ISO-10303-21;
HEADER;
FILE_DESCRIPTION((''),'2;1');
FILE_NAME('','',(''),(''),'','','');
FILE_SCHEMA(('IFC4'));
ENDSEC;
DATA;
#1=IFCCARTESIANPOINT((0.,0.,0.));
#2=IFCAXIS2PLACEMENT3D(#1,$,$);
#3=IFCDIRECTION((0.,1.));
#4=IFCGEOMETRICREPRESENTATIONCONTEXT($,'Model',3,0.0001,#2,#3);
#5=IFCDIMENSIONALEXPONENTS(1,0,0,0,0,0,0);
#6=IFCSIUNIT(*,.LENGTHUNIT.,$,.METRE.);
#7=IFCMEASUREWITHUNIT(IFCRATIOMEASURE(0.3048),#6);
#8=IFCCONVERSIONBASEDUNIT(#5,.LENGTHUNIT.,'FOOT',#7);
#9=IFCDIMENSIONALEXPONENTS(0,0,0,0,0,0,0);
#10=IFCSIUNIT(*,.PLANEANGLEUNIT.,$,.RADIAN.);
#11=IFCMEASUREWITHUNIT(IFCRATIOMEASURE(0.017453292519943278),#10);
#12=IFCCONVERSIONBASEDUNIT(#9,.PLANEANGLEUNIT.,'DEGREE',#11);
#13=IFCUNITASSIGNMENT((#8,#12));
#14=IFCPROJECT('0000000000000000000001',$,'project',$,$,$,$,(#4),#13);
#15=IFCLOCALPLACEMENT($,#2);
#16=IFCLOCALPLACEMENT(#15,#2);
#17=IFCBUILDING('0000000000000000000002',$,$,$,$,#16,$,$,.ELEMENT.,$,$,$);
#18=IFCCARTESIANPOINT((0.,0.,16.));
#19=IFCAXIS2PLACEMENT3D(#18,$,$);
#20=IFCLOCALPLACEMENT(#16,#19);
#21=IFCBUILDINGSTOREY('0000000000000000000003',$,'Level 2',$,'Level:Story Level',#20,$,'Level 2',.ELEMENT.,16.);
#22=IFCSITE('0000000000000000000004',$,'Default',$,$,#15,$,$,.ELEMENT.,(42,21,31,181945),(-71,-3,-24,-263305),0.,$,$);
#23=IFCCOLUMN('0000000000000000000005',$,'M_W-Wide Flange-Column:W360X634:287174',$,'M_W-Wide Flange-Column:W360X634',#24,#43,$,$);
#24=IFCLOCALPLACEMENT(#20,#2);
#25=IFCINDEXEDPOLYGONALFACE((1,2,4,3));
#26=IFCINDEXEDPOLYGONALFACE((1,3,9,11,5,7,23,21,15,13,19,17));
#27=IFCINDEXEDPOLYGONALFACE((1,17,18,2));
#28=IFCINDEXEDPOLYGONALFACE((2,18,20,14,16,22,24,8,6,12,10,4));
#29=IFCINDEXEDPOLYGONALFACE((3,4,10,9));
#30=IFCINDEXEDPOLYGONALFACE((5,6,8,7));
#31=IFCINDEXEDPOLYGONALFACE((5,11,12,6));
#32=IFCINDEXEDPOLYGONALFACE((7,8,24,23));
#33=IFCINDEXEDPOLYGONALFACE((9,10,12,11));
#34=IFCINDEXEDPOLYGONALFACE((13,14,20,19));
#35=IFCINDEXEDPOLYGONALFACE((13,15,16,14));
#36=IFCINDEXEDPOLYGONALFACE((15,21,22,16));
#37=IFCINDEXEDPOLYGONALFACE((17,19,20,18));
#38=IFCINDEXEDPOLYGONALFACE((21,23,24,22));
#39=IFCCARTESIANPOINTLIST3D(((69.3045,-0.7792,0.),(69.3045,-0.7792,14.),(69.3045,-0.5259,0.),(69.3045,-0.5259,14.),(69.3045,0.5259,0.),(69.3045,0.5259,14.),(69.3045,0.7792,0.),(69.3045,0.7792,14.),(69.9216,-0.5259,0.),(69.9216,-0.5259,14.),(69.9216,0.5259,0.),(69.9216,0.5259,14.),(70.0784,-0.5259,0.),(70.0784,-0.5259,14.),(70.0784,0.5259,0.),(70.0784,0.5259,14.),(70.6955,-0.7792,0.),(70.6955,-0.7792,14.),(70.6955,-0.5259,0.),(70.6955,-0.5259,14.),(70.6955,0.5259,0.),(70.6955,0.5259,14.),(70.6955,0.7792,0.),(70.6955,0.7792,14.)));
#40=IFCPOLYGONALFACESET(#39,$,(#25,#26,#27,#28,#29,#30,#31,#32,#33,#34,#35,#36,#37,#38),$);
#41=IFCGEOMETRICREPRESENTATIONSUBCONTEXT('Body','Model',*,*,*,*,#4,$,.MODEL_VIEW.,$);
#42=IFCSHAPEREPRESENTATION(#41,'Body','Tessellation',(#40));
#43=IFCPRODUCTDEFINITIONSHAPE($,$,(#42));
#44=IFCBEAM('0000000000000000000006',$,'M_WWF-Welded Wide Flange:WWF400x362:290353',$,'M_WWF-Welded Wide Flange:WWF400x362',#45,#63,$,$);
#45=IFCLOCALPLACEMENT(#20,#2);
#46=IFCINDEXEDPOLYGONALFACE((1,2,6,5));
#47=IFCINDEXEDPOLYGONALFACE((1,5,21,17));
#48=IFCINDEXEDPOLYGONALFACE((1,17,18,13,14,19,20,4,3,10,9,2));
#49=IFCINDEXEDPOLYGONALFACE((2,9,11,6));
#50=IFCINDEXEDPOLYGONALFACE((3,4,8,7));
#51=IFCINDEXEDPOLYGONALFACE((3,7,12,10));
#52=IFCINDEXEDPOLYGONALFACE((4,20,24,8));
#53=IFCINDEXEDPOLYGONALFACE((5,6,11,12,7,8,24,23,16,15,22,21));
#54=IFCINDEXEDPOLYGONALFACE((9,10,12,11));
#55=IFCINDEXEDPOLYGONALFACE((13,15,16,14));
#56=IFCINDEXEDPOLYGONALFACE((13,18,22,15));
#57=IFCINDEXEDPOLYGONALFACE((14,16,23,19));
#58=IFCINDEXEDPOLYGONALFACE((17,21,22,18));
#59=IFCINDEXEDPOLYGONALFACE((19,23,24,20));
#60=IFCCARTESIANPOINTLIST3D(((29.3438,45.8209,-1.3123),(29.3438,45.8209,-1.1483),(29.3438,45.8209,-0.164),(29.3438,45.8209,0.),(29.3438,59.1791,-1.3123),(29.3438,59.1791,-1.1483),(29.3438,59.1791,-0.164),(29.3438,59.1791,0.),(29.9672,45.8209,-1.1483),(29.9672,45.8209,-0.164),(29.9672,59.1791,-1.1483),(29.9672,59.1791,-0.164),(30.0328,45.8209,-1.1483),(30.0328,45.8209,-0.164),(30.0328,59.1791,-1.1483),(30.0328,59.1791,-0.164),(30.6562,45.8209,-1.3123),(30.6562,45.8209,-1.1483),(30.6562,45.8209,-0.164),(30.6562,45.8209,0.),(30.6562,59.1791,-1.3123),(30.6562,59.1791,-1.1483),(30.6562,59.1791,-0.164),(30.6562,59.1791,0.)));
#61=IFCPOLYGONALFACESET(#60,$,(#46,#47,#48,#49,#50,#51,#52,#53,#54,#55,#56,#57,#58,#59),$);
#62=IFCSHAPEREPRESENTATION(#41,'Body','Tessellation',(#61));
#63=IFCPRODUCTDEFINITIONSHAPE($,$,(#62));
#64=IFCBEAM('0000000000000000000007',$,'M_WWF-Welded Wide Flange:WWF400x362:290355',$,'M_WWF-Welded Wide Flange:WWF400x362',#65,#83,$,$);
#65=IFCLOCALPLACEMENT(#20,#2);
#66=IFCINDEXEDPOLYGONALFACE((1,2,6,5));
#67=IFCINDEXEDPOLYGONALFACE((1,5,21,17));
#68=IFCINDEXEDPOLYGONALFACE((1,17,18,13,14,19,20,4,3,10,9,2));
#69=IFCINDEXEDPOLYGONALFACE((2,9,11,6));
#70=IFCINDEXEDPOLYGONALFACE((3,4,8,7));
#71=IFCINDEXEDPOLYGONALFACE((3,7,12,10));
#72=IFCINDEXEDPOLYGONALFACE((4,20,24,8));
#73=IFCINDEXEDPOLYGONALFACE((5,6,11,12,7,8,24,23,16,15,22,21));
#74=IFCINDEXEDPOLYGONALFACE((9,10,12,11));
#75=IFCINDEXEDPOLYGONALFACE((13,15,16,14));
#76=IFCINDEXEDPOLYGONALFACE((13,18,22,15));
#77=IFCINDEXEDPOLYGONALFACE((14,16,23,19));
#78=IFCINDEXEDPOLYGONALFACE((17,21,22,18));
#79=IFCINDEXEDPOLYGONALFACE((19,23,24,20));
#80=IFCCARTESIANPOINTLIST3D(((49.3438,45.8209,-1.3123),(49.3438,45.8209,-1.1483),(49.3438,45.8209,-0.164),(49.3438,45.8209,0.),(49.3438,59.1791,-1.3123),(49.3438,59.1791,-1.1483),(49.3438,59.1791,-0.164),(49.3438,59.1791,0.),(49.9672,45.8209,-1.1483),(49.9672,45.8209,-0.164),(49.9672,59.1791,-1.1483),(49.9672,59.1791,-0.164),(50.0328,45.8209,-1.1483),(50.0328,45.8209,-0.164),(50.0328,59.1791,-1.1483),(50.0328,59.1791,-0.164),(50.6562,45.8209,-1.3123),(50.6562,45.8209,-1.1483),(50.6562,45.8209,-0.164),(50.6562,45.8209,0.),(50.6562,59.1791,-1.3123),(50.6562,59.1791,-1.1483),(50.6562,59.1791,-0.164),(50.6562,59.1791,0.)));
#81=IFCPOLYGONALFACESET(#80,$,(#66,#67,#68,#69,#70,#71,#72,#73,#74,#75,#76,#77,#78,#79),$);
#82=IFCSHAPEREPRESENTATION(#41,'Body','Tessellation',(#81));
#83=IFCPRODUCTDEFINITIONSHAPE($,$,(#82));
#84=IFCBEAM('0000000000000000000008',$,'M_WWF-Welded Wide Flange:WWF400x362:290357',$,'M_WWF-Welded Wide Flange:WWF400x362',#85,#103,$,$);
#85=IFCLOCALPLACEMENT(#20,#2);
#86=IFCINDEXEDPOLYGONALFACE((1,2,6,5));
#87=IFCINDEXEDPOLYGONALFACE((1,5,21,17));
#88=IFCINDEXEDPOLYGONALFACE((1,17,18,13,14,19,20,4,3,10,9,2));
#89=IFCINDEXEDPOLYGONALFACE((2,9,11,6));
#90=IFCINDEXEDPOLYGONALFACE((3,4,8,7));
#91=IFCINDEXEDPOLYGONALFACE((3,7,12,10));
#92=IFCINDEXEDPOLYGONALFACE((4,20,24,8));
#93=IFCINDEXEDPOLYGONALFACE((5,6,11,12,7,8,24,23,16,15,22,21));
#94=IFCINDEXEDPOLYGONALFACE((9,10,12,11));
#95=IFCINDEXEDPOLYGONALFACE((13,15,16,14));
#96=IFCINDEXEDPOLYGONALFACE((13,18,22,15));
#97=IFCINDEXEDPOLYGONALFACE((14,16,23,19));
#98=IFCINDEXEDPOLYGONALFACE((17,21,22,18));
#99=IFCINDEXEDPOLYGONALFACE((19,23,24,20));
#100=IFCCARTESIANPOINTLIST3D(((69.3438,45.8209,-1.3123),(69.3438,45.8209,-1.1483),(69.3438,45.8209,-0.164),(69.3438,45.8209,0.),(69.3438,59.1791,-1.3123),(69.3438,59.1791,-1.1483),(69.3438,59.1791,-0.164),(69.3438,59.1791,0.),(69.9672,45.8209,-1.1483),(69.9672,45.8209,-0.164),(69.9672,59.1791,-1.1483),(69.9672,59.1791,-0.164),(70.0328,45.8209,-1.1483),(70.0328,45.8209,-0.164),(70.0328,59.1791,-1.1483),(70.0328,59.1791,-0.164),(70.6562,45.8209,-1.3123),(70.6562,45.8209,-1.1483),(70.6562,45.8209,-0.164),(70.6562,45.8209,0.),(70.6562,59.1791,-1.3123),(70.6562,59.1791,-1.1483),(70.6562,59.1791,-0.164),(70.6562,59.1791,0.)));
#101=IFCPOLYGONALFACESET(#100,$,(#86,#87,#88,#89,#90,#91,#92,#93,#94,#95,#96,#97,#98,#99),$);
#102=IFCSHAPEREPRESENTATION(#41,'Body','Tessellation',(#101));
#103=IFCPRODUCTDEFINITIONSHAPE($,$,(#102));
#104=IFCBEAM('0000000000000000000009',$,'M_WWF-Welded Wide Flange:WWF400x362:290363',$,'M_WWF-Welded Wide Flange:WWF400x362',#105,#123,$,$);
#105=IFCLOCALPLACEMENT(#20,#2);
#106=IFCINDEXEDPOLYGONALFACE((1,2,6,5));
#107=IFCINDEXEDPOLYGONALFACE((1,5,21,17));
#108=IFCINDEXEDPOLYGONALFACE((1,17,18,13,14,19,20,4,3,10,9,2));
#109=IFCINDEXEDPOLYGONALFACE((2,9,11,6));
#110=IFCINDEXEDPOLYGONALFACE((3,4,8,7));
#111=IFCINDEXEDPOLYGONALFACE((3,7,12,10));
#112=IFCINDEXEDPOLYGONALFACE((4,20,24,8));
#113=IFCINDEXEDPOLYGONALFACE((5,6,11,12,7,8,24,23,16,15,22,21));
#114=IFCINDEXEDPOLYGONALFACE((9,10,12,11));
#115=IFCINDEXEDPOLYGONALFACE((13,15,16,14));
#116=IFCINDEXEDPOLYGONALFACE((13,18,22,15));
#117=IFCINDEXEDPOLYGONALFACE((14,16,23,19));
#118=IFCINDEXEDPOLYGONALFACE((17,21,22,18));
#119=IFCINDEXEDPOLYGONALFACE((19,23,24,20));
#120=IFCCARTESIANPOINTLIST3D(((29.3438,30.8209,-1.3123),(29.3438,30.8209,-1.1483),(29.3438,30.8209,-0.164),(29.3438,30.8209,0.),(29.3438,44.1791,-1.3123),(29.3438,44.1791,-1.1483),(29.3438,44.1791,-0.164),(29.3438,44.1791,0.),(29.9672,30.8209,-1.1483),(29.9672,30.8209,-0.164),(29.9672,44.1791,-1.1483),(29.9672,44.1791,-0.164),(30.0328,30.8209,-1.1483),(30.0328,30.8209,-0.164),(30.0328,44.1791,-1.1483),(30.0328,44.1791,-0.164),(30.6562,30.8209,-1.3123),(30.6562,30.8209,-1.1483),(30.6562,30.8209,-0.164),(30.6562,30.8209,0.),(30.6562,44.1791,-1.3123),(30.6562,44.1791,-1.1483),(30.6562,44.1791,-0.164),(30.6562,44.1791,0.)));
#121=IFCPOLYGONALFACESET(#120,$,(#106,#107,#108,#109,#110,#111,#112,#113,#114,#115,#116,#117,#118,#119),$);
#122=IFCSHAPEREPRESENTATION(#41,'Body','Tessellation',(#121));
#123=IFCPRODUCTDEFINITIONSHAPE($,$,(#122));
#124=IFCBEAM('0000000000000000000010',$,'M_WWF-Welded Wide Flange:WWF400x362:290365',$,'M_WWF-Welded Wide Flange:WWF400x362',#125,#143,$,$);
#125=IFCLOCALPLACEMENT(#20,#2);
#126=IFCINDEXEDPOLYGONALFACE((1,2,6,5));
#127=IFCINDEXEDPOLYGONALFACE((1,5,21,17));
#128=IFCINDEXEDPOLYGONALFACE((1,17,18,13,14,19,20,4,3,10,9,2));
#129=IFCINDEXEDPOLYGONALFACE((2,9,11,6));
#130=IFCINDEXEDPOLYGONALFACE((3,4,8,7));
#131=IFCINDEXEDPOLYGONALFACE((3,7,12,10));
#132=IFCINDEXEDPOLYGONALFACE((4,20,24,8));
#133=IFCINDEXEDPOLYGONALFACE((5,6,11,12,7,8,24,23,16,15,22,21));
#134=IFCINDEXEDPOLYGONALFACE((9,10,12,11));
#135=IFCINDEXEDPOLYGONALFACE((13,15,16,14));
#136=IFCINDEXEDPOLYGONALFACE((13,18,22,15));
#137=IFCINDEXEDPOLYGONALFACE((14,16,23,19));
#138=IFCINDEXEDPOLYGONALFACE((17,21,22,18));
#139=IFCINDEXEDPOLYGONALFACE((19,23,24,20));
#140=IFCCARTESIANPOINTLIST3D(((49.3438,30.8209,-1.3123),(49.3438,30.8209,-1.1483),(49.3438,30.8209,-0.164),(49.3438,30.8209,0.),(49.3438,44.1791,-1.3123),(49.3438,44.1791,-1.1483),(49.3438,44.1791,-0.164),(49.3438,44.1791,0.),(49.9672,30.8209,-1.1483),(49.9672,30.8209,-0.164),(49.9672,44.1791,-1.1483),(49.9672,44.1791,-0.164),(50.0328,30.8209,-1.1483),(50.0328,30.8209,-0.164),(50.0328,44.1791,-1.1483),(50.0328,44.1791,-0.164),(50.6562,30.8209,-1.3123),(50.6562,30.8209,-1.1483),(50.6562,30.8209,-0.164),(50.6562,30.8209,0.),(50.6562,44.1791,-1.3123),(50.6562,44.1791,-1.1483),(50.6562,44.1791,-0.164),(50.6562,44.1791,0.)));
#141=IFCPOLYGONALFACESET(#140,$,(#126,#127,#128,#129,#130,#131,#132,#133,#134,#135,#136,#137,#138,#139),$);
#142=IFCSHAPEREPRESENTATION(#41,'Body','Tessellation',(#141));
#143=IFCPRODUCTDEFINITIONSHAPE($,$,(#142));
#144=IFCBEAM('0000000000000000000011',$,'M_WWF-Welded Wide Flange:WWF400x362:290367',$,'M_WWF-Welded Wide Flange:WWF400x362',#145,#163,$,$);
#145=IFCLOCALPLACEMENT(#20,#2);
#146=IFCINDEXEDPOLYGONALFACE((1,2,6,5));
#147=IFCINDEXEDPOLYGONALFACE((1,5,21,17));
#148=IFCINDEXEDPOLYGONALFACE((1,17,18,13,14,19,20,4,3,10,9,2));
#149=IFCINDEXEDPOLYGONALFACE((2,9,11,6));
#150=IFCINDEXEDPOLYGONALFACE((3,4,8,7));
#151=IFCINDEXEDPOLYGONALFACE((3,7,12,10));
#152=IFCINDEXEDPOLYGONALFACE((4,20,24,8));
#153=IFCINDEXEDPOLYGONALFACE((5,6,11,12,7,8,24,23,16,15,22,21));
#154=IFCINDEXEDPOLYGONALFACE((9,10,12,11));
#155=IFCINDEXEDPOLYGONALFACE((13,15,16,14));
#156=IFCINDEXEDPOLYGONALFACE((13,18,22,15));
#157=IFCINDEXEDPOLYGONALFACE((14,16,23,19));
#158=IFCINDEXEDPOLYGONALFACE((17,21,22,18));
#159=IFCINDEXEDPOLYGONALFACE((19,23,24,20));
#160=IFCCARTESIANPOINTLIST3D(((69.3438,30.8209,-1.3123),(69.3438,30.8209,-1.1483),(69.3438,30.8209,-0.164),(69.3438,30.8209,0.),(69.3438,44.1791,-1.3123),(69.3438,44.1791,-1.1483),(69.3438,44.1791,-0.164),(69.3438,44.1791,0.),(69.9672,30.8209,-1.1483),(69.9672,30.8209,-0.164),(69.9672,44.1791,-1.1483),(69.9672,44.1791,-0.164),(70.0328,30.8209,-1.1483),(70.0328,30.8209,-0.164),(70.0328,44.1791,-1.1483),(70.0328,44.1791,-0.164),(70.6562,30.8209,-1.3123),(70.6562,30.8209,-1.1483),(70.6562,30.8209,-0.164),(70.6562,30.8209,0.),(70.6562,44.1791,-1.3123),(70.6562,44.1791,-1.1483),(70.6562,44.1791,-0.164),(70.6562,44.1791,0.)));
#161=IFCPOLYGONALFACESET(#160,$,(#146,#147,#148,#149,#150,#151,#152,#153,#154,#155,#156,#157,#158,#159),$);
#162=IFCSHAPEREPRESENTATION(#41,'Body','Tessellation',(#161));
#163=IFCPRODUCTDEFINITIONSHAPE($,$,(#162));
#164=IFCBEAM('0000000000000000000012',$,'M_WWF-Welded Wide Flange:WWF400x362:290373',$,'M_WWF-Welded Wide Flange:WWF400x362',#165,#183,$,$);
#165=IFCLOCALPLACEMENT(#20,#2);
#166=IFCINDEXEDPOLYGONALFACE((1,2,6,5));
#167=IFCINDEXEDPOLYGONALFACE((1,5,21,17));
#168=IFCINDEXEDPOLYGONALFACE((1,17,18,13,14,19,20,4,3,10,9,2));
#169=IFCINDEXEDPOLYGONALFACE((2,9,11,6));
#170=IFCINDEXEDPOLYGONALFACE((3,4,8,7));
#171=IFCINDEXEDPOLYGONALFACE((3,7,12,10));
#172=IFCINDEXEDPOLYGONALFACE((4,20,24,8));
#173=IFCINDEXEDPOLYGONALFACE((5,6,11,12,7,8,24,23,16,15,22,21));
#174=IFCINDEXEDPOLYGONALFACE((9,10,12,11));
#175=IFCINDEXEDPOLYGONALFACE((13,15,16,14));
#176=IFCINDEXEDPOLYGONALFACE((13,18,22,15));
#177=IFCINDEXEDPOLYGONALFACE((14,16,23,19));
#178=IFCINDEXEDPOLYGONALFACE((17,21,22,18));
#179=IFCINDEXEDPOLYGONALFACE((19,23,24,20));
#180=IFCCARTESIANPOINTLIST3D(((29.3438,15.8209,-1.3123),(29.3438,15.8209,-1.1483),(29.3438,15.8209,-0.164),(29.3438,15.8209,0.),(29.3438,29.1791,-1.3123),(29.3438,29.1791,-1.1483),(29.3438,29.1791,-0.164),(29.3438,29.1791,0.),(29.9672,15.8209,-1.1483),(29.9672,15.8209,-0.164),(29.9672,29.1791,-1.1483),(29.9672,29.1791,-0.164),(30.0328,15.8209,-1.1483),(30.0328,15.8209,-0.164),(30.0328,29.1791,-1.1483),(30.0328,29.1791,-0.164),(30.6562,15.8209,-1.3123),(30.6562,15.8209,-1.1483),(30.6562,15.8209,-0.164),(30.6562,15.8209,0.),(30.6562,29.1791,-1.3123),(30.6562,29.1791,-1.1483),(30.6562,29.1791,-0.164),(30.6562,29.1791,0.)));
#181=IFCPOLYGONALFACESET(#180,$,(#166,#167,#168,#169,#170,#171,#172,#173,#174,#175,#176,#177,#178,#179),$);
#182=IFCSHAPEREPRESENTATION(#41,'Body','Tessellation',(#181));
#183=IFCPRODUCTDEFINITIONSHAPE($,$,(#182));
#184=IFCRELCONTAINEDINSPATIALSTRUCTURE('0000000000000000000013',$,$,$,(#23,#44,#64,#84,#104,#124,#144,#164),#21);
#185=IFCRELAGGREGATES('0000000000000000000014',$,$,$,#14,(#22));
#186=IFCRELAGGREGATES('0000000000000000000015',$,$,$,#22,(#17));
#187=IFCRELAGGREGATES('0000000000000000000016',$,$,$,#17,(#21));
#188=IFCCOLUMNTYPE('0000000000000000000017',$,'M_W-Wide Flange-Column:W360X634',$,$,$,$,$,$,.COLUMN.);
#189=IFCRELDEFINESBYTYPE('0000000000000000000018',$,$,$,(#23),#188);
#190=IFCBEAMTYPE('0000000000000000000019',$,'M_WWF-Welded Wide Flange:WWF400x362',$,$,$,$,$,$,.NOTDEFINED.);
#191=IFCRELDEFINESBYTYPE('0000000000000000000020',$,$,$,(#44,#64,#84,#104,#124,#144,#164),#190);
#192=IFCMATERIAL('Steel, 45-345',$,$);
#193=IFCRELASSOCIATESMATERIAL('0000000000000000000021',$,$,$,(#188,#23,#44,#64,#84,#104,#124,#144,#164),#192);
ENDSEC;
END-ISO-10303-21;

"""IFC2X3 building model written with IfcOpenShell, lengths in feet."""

from ifc_helpers import new_model, entity, si_unit, converted_unit, direction, frame, frame_2d, origin, place, context, subcontext, project, spatial, polyline, i_section, outline, extrude, source, transform, mapped, material, type_object, type_shapes, element, save


model = new_model("IFC2X3")

# Units and contexts
model_context = context("Model", 3, precision=0.0001, world=origin(), true_north=direction((0.0, 1.0)))
body_context = subcontext(model_context, "Body", "Model", "MODEL_VIEW")
ifc_project = project(units=[converted_unit("LENGTHUNIT", "FOOT", entity("IfcRatioMeasure", 0.3048), si_unit("LENGTHUNIT", "METRE"), dimensions=[1, 0, 0, 0, 0, 0, 0]), converted_unit("PLANEANGLEUNIT", "DEGREE", entity("IfcRatioMeasure", 0.017453292519943278), si_unit("PLANEANGLEUNIT", "RADIAN"), dimensions=[0, 0, 0, 0, 0, 0, 0])], contexts=[model_context])

# Site, building, storey
site_placement = place(None, origin())
site = spatial("IfcSite", under=ifc_project, at=site_placement, Name="Default", CompositionType="ELEMENT", RefLatitude=(42, 21, 31, 181945), RefLongitude=(-71, -3, -24, -263305), RefElevation=0.0)
building_placement = place(site_placement, origin())
building = spatial("IfcBuilding", under=site, at=building_placement, CompositionType="ELEMENT")
storey_placement = place(building_placement, frame((0.0, 0.0, 16.0)))
storey = spatial("IfcBuildingStorey", under=building, at=storey_placement, Name="Level 2", ObjectType="Level:Story Level", LongName="Level 2", CompositionType="ELEMENT", Elevation=16.0)

# Column
ifc_material = material(Name="Steel, 45-345")
column_type = type_object("IfcColumnType", Name="M_W-Wide Flange-Column:W360X634", PredefinedType="COLUMN", material=ifc_material)
shared_shape = source(origin(), body_context, "Body", "SweptSolid", [
    extrude(outline(polyline([(0.5259, -0.6955), (0.7792, -0.6955), (0.7792, 0.6955), (0.5259, 0.6955), (0.5259, 0.0784), (-0.5259, 0.0784), (-0.5259, 0.6955), (-0.7792, 0.6955), (-0.7792, -0.6955), (-0.5259, -0.6955), (-0.5259, -0.0784), (0.5259, -0.0784), (0.5259, -0.6955)])), frame((0.0, 0.0, 16.0), z_axis=(0.0, 0.0, 1.0), x_axis=(0.0, -1.0, 0.0)), (0.0, 0.0, 1.0), 14.0),
])
type_shapes(column_type, [shared_shape])
for number, where, name in (
    (1, (70.0, 0.0, -16.0), "M_W-Wide Flange-Column:W360X634:287174"),
):
    element("IfcColumn", number, at=place(storey_placement, frame(where)), inside=storey, type_object=column_type, material=ifc_material, Name=name, ObjectType="M_W-Wide Flange-Column:W360X634", context=body_context, shape_type="MappedRepresentation", body=[
        mapped(shared_shape, transform((0.0, 0.0, 0.0), scale=1.0)),
    ])

# Beams
beam_type = type_object("IfcBeamType", Name="M_WWF-Welded Wide Flange:WWF400x362", PredefinedType="NOTDEFINED")
beam_1_placement = place(storey_placement, frame((30.0, 45.0, 0.0), z_axis=(0.0, 0.0, 1.0), x_axis=(0.0, 1.0, 0.0)))
element("IfcBeam", 2, at=beam_1_placement, inside=storey, type_object=beam_type, material=ifc_material, Name="M_WWF-Welded Wide Flange:WWF400x362:290353", ObjectType="M_WWF-Welded Wide Flange:WWF400x362", context=body_context, shape_type="SweptSolid", body=[
    extrude(i_section(OverallWidth=1.3123, OverallDepth=1.3123, WebThickness=0.0656, FlangeThickness=0.164, at=frame_2d((0.0, 0.0), x_axis=(0.0, 1.0))), frame((0.8209, 0.0, -0.6562), z_axis=(1.0, 0.0, 0.0), x_axis=(0.0, 0.0, -1.0)), (0.0, 0.0, 1.0), 13.3583),
])
beam_2_placement = place(storey_placement, frame((50.0, 45.0, 0.0), z_axis=(0.0, 0.0, 1.0), x_axis=(0.0, 1.0, 0.0)))
element("IfcBeam", 3, at=beam_2_placement, inside=storey, type_object=beam_type, material=ifc_material, Name="M_WWF-Welded Wide Flange:WWF400x362:290355", ObjectType="M_WWF-Welded Wide Flange:WWF400x362", context=body_context, shape_type="SweptSolid", body=[
    extrude(i_section(OverallWidth=1.3123, OverallDepth=1.3123, WebThickness=0.0656, FlangeThickness=0.164, at=frame_2d((0.0, 0.0), x_axis=(0.0, 1.0))), frame((0.8209, 0.0, -0.6562), z_axis=(1.0, 0.0, 0.0), x_axis=(0.0, 0.0, -1.0)), (0.0, 0.0, 1.0), 13.3583),
])
beam_3_placement = place(storey_placement, frame((70.0, 45.0, 0.0), z_axis=(0.0, 0.0, 1.0), x_axis=(0.0, 1.0, 0.0)))
element("IfcBeam", 4, at=beam_3_placement, inside=storey, type_object=beam_type, material=ifc_material, Name="M_WWF-Welded Wide Flange:WWF400x362:290357", ObjectType="M_WWF-Welded Wide Flange:WWF400x362", context=body_context, shape_type="SweptSolid", body=[
    extrude(i_section(OverallWidth=1.3123, OverallDepth=1.3123, WebThickness=0.0656, FlangeThickness=0.164, at=frame_2d((0.0, 0.0), x_axis=(0.0, 1.0))), frame((0.8209, 0.0, -0.6562), z_axis=(1.0, 0.0, 0.0), x_axis=(0.0, 0.0, -1.0)), (0.0, 0.0, 1.0), 13.3583),
])
beam_4_placement = place(storey_placement, frame((30.0, 30.0, 0.0), z_axis=(0.0, 0.0, 1.0), x_axis=(0.0, 1.0, 0.0)))
element("IfcBeam", 5, at=beam_4_placement, inside=storey, type_object=beam_type, material=ifc_material, Name="M_WWF-Welded Wide Flange:WWF400x362:290363", ObjectType="M_WWF-Welded Wide Flange:WWF400x362", context=body_context, shape_type="SweptSolid", body=[
    extrude(i_section(OverallWidth=1.3123, OverallDepth=1.3123, WebThickness=0.0656, FlangeThickness=0.164, at=frame_2d((0.0, 0.0), x_axis=(0.0, 1.0))), frame((0.8209, 0.0, -0.6562), z_axis=(1.0, 0.0, 0.0), x_axis=(0.0, 0.0, -1.0)), (0.0, 0.0, 1.0), 13.3583),
])
for number, where, z_axis, x_axis, name in (
    (6, (50.0, 30.0, 0.0), (0.0, 0.0, 1.0), (0.0, 1.0, 0.0), "M_WWF-Welded Wide Flange:WWF400x362:290365"),
    (7, (70.0, 30.0, 0.0), (0.0, 0.0, 1.0), (0.0, 1.0, 0.0), "M_WWF-Welded Wide Flange:WWF400x362:290367"),
):
    element("IfcBeam", number, at=place(storey_placement, frame(where, z_axis=z_axis, x_axis=x_axis)), inside=storey, type_object=beam_type, material=ifc_material, Name=name, ObjectType="M_WWF-Welded Wide Flange:WWF400x362", context=body_context, shape_type="SweptSolid", body=[
        extrude(i_section(OverallWidth=1.3123, OverallDepth=1.3123, WebThickness=0.0656, FlangeThickness=0.164, at=frame_2d((0.0, 0.0), x_axis=(0.0, 1.0))), frame((0.8209, 0.0, -0.6562), z_axis=(1.0, 0.0, 0.0), x_axis=(0.0, 0.0, -1.0)), (0.0, 0.0, 1.0), 13.3583),
    ])
beam_5_placement = place(storey_placement, frame((30.0, 15.0, 0.0), z_axis=(0.0, 0.0, 1.0), x_axis=(0.0, 1.0, 0.0)))
element("IfcBeam", 8, at=beam_5_placement, inside=storey, type_object=beam_type, material=ifc_material, Name="M_WWF-Welded Wide Flange:WWF400x362:290373", ObjectType="M_WWF-Welded Wide Flange:WWF400x362", context=body_context, shape_type="SweptSolid", body=[
    extrude(i_section(OverallWidth=1.3123, OverallDepth=1.3123, WebThickness=0.0656, FlangeThickness=0.164, at=frame_2d((0.0, 0.0), x_axis=(0.0, 1.0))), frame((0.8209, 0.0, -0.6562), z_axis=(1.0, 0.0, 0.0), x_axis=(0.0, 0.0, -1.0)), (0.0, 0.0, 1.0), 13.3583),
])

save(model, "model.ifc")
